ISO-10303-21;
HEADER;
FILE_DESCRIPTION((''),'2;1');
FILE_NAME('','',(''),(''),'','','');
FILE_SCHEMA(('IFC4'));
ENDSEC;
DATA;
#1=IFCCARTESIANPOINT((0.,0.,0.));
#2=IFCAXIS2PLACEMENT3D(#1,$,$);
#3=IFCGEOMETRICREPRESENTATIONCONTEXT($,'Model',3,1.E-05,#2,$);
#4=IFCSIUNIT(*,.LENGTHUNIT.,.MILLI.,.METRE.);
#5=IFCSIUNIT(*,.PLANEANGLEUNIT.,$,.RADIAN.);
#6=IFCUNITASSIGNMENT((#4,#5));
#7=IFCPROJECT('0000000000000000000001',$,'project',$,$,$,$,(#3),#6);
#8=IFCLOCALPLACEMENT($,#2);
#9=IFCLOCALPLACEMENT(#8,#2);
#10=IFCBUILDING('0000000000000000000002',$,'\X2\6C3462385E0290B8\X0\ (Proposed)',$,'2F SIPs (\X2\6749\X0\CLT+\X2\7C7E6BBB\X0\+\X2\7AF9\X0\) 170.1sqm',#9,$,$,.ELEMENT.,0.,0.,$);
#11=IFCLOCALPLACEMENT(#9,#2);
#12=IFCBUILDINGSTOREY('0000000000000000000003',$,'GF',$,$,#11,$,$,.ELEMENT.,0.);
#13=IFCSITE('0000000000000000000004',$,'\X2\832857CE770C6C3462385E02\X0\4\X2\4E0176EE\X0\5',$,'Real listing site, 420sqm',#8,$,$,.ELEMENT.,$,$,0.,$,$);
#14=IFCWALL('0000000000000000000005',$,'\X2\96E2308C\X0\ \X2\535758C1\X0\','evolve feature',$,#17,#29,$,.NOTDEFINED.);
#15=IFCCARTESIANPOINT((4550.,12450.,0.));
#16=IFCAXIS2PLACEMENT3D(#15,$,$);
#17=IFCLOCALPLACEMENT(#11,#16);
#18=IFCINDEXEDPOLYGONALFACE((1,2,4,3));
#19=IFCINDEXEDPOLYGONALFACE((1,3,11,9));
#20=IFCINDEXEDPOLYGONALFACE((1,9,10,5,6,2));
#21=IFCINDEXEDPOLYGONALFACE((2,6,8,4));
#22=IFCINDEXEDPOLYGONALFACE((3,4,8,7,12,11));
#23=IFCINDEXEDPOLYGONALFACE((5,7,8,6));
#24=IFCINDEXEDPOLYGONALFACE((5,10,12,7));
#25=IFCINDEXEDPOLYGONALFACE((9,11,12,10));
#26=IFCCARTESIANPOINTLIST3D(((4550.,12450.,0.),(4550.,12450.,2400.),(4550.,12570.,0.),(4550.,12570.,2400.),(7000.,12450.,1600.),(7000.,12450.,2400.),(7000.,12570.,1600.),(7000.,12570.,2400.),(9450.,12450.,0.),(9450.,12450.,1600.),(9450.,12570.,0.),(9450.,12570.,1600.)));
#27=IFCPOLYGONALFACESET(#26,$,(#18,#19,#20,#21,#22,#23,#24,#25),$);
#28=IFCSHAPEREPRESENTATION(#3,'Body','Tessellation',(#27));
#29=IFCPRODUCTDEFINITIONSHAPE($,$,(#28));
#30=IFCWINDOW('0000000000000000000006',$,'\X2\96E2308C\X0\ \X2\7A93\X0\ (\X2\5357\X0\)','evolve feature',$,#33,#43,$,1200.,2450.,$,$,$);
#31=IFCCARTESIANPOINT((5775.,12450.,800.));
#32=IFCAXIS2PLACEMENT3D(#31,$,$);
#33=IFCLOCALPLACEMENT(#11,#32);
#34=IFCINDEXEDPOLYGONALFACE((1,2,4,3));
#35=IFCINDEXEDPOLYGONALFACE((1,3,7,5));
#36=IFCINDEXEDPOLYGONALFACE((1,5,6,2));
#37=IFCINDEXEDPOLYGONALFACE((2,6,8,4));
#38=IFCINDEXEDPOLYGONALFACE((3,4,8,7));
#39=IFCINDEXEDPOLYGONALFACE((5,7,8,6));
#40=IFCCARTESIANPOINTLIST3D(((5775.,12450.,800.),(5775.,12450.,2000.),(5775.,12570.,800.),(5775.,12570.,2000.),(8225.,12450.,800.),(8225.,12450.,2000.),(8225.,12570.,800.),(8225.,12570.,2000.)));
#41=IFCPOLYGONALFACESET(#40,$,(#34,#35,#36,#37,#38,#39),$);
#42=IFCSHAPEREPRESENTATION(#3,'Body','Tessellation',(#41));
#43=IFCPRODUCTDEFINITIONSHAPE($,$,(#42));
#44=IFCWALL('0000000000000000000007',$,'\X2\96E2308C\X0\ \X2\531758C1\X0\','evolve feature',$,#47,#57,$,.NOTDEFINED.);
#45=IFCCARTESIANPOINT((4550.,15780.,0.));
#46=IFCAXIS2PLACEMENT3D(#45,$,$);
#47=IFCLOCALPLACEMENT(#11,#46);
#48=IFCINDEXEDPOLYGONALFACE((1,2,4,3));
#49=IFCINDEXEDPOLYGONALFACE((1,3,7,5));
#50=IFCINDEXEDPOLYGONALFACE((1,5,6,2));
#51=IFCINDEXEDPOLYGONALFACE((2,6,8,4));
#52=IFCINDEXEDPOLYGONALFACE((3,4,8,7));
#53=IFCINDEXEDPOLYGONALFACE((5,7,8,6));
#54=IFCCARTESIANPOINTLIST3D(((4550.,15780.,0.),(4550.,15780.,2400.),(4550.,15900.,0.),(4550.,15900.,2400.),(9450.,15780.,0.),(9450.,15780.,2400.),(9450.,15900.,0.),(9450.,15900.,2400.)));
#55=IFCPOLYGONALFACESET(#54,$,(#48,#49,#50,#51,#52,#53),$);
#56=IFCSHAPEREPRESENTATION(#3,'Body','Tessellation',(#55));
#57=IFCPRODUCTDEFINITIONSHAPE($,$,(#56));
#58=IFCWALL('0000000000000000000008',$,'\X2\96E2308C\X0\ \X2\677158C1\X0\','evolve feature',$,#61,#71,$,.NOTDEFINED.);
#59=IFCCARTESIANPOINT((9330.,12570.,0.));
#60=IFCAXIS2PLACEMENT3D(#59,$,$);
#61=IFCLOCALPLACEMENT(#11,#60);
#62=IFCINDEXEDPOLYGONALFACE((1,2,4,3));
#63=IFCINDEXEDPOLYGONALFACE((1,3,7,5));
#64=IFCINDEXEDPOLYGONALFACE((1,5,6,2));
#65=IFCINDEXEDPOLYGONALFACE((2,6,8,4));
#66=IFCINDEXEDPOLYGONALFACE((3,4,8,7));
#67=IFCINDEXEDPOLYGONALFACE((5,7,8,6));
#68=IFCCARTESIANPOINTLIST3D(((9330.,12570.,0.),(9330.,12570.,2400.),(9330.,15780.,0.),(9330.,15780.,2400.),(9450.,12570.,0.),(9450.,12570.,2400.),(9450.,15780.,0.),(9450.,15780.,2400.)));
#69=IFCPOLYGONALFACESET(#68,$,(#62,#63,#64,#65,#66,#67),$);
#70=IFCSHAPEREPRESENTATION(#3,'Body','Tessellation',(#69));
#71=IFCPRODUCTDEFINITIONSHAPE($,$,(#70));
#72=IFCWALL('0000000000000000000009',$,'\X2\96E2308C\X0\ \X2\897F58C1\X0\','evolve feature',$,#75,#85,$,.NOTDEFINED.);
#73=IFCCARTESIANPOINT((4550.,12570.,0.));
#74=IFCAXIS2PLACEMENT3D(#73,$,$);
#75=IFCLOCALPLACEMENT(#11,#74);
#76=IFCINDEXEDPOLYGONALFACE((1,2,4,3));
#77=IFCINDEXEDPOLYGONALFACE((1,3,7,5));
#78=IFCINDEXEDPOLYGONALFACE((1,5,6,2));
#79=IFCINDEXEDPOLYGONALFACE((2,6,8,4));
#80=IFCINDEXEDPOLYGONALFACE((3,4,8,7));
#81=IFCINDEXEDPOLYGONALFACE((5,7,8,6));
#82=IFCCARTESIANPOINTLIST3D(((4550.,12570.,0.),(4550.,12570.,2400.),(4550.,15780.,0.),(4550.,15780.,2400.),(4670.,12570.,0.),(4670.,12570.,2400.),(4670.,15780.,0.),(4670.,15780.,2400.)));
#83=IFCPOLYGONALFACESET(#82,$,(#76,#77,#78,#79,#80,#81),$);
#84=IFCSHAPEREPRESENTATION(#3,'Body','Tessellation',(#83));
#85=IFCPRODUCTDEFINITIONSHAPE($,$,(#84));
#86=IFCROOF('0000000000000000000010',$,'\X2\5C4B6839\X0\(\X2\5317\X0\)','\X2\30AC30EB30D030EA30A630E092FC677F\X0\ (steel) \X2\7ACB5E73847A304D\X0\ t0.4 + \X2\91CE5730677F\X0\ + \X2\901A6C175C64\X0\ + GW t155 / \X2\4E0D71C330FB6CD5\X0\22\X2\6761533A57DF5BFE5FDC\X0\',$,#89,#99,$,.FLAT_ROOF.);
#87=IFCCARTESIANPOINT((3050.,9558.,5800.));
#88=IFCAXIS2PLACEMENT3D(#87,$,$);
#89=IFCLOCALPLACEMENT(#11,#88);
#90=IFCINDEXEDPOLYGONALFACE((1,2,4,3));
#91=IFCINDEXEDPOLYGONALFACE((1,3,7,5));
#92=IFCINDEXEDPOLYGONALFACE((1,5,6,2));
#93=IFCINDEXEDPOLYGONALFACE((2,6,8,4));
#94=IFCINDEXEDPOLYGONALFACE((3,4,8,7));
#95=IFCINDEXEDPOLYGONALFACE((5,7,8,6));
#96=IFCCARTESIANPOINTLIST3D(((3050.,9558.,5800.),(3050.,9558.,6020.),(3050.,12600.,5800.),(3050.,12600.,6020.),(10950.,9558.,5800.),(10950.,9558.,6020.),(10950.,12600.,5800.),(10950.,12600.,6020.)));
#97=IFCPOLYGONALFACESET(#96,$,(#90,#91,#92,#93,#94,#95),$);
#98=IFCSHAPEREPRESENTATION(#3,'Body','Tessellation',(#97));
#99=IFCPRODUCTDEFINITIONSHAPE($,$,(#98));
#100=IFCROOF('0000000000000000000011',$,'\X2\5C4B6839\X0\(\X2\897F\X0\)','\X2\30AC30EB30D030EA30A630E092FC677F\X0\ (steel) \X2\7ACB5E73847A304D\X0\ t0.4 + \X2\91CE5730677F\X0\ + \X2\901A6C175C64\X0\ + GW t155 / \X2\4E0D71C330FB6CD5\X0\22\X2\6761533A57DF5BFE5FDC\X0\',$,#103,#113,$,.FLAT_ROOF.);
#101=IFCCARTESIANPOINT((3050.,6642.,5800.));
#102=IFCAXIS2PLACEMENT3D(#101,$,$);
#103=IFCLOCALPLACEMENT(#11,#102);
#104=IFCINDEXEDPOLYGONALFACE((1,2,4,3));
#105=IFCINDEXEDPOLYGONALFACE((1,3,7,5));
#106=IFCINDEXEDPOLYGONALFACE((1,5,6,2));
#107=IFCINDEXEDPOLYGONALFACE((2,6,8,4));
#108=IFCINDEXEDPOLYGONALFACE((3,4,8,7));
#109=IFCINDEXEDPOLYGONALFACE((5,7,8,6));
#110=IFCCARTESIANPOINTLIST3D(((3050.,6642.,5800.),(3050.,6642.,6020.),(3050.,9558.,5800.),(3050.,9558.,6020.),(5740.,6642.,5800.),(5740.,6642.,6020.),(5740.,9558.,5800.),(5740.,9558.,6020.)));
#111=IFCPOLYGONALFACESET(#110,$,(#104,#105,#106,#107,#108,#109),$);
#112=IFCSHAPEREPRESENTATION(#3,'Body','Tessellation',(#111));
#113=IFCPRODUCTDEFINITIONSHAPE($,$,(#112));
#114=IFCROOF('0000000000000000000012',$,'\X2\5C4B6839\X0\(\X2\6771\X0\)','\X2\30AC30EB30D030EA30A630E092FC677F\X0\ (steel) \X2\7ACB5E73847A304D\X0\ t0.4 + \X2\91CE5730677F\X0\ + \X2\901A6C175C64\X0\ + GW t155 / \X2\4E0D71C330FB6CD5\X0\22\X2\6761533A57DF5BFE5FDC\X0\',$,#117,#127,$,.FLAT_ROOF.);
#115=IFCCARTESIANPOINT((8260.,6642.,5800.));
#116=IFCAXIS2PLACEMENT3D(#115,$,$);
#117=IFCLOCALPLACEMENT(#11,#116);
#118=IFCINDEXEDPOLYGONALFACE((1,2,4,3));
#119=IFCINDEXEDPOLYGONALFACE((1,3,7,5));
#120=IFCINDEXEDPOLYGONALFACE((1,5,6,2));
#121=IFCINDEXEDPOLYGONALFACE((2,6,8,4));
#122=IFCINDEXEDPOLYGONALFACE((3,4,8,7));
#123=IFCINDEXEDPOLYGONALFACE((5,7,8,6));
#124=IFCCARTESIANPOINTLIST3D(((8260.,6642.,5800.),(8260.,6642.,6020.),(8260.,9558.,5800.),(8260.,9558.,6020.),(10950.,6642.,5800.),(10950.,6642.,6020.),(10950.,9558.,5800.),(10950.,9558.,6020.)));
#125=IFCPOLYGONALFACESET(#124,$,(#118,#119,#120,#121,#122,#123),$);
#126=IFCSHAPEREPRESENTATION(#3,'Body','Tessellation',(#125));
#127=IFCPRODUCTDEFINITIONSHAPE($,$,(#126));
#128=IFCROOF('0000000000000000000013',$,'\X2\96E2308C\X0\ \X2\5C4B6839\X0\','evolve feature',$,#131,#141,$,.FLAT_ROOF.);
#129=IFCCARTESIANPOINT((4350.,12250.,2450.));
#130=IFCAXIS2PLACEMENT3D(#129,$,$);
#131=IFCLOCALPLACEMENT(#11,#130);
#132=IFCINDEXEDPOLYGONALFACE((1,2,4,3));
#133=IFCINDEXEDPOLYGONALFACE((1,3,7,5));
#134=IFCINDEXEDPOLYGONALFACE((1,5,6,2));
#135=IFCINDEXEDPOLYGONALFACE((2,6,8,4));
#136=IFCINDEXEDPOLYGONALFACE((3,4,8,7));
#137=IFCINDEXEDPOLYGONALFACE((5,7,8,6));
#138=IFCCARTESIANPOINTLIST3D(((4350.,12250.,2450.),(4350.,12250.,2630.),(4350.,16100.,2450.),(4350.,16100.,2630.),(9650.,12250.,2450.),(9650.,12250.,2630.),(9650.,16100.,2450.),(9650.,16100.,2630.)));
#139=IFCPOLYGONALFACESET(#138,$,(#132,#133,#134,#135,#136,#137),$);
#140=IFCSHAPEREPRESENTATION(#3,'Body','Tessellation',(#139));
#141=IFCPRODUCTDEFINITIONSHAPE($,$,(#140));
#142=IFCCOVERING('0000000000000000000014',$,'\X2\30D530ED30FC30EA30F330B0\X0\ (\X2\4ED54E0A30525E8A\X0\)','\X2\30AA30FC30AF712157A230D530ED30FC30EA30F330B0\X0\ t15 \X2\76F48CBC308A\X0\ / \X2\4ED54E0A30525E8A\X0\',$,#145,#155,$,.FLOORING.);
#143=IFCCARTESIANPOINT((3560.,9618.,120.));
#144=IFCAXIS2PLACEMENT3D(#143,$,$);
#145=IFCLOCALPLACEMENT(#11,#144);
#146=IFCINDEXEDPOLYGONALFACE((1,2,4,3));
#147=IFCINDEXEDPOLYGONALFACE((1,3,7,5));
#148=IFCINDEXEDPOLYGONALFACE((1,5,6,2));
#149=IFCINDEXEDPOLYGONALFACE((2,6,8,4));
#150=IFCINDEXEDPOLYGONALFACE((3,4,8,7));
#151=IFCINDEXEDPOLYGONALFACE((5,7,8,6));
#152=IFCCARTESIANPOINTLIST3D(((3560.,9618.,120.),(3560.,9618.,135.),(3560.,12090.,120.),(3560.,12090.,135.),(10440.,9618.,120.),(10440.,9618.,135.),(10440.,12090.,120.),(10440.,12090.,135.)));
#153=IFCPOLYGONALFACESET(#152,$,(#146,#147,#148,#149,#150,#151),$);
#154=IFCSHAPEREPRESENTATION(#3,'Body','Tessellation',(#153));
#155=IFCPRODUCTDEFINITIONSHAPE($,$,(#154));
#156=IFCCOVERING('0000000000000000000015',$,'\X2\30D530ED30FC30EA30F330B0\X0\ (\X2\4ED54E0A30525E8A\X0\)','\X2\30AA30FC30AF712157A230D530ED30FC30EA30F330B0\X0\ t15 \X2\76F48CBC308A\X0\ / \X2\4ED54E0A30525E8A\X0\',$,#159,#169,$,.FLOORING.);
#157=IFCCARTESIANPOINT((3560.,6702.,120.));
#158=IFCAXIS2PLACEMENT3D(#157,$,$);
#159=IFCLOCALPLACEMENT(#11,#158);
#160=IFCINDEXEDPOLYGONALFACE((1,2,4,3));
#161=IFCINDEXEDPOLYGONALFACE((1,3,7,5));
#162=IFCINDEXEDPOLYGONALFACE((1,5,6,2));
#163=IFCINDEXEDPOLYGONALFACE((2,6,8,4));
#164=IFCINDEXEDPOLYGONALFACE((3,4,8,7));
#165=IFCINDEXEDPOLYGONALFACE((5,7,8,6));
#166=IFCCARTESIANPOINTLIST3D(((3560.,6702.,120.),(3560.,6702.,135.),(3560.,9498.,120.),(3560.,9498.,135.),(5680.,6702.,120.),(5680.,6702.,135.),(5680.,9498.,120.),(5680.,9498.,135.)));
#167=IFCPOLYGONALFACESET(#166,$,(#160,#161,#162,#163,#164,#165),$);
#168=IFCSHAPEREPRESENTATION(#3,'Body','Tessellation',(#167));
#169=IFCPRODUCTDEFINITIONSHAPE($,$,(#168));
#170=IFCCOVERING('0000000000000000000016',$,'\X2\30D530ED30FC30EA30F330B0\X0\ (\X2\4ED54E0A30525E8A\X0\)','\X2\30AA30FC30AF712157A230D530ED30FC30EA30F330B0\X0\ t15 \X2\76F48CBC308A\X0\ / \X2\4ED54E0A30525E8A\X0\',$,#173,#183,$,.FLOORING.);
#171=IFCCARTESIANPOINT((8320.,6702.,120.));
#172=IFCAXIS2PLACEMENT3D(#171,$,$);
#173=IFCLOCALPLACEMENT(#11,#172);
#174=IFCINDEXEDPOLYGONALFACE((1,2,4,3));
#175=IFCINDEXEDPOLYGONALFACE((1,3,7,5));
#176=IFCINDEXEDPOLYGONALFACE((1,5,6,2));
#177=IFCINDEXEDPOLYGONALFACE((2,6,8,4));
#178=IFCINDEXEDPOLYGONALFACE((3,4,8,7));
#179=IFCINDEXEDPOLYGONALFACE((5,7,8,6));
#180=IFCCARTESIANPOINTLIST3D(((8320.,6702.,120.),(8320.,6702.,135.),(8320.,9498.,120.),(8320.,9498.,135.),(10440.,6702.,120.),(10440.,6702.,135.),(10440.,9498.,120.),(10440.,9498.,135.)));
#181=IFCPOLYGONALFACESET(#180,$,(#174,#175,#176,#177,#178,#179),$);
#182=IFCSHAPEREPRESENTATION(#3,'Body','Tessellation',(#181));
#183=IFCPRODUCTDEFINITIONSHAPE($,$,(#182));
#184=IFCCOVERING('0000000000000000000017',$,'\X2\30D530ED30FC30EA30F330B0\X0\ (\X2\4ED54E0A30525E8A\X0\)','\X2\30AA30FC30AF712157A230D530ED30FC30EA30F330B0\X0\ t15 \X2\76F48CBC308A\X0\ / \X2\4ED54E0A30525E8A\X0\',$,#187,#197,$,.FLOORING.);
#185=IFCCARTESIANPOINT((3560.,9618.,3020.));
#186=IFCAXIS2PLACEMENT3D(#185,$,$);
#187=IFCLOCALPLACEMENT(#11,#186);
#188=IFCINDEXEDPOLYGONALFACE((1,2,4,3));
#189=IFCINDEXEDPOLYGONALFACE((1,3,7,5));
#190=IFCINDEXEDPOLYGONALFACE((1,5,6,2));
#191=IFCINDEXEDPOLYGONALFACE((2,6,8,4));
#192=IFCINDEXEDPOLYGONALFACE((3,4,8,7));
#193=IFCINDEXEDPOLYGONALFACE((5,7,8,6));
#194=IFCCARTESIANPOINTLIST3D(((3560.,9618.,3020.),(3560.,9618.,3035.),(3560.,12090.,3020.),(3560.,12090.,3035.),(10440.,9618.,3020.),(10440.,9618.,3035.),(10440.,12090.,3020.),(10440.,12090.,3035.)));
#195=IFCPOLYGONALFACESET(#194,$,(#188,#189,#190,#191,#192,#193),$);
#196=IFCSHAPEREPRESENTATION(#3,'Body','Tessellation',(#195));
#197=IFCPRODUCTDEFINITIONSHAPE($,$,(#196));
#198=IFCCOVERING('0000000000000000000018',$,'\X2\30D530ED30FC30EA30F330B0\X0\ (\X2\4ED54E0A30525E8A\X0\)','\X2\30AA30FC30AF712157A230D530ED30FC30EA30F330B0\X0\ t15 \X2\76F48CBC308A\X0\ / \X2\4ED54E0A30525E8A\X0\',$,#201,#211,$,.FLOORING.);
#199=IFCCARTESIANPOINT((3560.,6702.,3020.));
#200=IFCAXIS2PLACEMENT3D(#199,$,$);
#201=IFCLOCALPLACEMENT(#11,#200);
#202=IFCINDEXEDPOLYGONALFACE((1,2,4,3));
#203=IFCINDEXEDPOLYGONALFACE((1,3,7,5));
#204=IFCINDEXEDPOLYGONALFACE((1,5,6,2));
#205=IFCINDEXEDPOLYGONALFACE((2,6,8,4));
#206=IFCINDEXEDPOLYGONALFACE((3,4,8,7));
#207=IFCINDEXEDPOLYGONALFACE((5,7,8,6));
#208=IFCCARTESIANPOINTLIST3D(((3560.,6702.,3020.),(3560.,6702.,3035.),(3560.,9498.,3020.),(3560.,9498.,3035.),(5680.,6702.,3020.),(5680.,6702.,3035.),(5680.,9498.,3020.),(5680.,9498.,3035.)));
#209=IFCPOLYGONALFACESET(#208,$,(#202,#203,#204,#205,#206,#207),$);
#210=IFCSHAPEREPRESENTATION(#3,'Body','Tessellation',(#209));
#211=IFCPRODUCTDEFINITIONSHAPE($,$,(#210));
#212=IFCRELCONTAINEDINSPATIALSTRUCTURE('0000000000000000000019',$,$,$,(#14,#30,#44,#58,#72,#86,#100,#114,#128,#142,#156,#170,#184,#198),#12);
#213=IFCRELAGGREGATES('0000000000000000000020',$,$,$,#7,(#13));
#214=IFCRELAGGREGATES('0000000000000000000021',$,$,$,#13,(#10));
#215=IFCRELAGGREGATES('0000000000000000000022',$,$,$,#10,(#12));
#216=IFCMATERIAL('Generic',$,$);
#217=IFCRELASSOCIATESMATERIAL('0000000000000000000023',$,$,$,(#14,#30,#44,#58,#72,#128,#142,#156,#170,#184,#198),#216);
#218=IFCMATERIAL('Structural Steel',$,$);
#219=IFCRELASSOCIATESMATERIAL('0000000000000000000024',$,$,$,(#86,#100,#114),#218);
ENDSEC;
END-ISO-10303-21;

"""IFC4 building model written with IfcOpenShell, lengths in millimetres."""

from ifc_helpers import new_model, si_unit, frame, frame_2d, origin, place, context, project, spatial, rectangle, extrude, material, element, fill, save


model = new_model("IFC4")

# Units and contexts
model_context = context("Model", 3, precision=1e-05, world=origin())
ifc_project = project(units=[si_unit("LENGTHUNIT", "METRE", prefix="MILLI"), si_unit("PLANEANGLEUNIT", "RADIAN")], contexts=[model_context])

# Site, building, storey
site_placement = place(None, origin())
site = spatial("IfcSite", under=ifc_project, at=site_placement, Name="茨城県水戸市4丁目5", ObjectType="Real listing site, 420sqm", CompositionType="ELEMENT", RefElevation=0.0)
building_placement = place(site_placement, origin())
building = spatial("IfcBuilding", under=site, at=building_placement, Name="水戸市邸 (Proposed)", ObjectType="2F SIPs (杉CLT+籾殻+竹) 170.1sqm", CompositionType="ELEMENT", ElevationOfRefHeight=0.0, ElevationOfTerrain=0.0)
storey_placement = place(building_placement, origin())
storey = spatial("IfcBuildingStorey", under=building, at=storey_placement, Name="GF", CompositionType="ELEMENT", Elevation=0.0)

# Shared definitions
ifc_material_1 = material(Name="Generic")

# Wall, opening, window
wall_1_placement = place(storey_placement, frame((4550.0, 12450.0, 0.0)))
wall_1 = element("IfcWall", 1, at=wall_1_placement, inside=storey, material=ifc_material_1, Name="離れ 南壁", Description="evolve feature", PredefinedType="NOTDEFINED", context=model_context, shape_type="SweptSolid", body=[
    extrude(rectangle(XDim=4900.0, YDim=120.0, at=frame_2d((2450.0, 60.0))), frame((4550.0, 12450.0, 0.0)), (0.0, 0.0, 1.0), 2400.0),
])
opening_1_placement = place(storey_placement, frame((5775.0, 12450.0, 800.0)))
opening_1 = element("IfcOpeningElement", 2, at=opening_1_placement, cuts=wall_1, PredefinedType="NOTDEFINED", context=model_context, shape_type="SweptSolid", body=[
    extrude(rectangle(XDim=2450.0, YDim=120.0, at=frame_2d((1225.0, 60.0))), frame((5775.0, 12450.0, 800.0)), (0.0, 0.0, 1.0), 1200.0),
])
window_1_placement = place(storey_placement, frame((5775.0, 12450.0, 800.0)))
window_1 = element("IfcWindow", 3, at=window_1_placement, inside=storey, material=ifc_material_1, Name="離れ 窓 (南)", Description="evolve feature", OverallHeight=1200.0, OverallWidth=2450.0, context=model_context, shape_type="SweptSolid", body=[
    extrude(rectangle(XDim=2450.0, YDim=120.0, at=frame_2d((1225.0, 60.0))), frame((5775.0, 12450.0, 800.0)), (0.0, 0.0, 1.0), 1200.0),
])
fill(opening_1, window_1)

# Walls
wall_2_placement = place(storey_placement, frame((4550.0, 15780.0, 0.0)))
element("IfcWall", 4, at=wall_2_placement, inside=storey, material=ifc_material_1, Name="離れ 北壁", Description="evolve feature", PredefinedType="NOTDEFINED", context=model_context, shape_type="SweptSolid", body=[
    extrude(rectangle(XDim=4900.0, YDim=120.0, at=frame_2d((2450.0, 60.0))), frame((4550.0, 15780.0, 0.0)), (0.0, 0.0, 1.0), 2400.0),
])
wall_3_placement = place(storey_placement, frame((9330.0, 12570.0, 0.0)))
element("IfcWall", 5, at=wall_3_placement, inside=storey, material=ifc_material_1, Name="離れ 東壁", Description="evolve feature", PredefinedType="NOTDEFINED", context=model_context, shape_type="SweptSolid", body=[
    extrude(rectangle(XDim=120.0, YDim=3210.0, at=frame_2d((60.0, 1605.0))), frame((9330.0, 12570.0, 0.0)), (0.0, 0.0, 1.0), 2400.0),
])
wall_4_placement = place(storey_placement, frame((4550.0, 12570.0, 0.0)))
element("IfcWall", 6, at=wall_4_placement, inside=storey, material=ifc_material_1, Name="離れ 西壁", Description="evolve feature", PredefinedType="NOTDEFINED", context=model_context, shape_type="SweptSolid", body=[
    extrude(rectangle(XDim=120.0, YDim=3210.0, at=frame_2d((60.0, 1605.0))), frame((4550.0, 12570.0, 0.0)), (0.0, 0.0, 1.0), 2400.0),
])

# Roofs
ifc_material_2 = material(Name="Structural Steel")
for number, where, name in (
    (7, (3050.0, 9558.0, 5800.0), "屋根(北)"),
):
    element("IfcRoof", number, at=place(storey_placement, frame(where)), inside=storey, material=ifc_material_2, Name=name, Description="ガルバリウム鋼板 (steel) 立平葺き t0.4 + 野地板 + 通気層 + GW t155 / 不燃・法22条区域対応", PredefinedType="FLAT_ROOF", context=model_context, shape_type="SweptSolid", body=[
        extrude(rectangle(XDim=7900.0, YDim=3042.0, at=frame_2d((3950.0, 1521.0))), frame((3050.0, 9558.0, 5800.0)), (0.0, 0.0, 1.0), 220.0),
    ])
roof_1_placement = place(storey_placement, frame((3050.0, 6642.0, 5800.0)))
element("IfcRoof", 8, at=roof_1_placement, inside=storey, material=ifc_material_2, Name="屋根(西)", Description="ガルバリウム鋼板 (steel) 立平葺き t0.4 + 野地板 + 通気層 + GW t155 / 不燃・法22条区域対応", PredefinedType="FLAT_ROOF", context=model_context, shape_type="SweptSolid", body=[
    extrude(rectangle(XDim=2690.0, YDim=2916.0, at=frame_2d((1345.0, 1458.0))), frame((3050.0, 6642.0, 5800.0)), (0.0, 0.0, 1.0), 220.0),
])
roof_2_placement = place(storey_placement, frame((8260.0, 6642.0, 5800.0)))
element("IfcRoof", 9, at=roof_2_placement, inside=storey, material=ifc_material_2, Name="屋根(東)", Description="ガルバリウム鋼板 (steel) 立平葺き t0.4 + 野地板 + 通気層 + GW t155 / 不燃・法22条区域対応", PredefinedType="FLAT_ROOF", context=model_context, shape_type="SweptSolid", body=[
    extrude(rectangle(XDim=2690.0, YDim=2916.0, at=frame_2d((1345.0, 1458.0))), frame((8260.0, 6642.0, 5800.0)), (0.0, 0.0, 1.0), 220.0),
])
roof_3_placement = place(storey_placement, frame((4350.0, 12250.0, 2450.0)))
element("IfcRoof", 10, at=roof_3_placement, inside=storey, material=ifc_material_1, Name="離れ 屋根", Description="evolve feature", PredefinedType="FLAT_ROOF", context=model_context, shape_type="SweptSolid", body=[
    extrude(rectangle(XDim=5300.0, YDim=3850.0, at=frame_2d((2650.0, 1925.0))), frame((4350.0, 12250.0, 2450.0)), (0.0, 0.0, 1.0), 180.0),
])

# Coverings
covering_1_placement = place(storey_placement, frame((3560.0, 9618.0, 120.0)))
element("IfcCovering", 11, at=covering_1_placement, inside=storey, material=ifc_material_1, Name="フローリング (仕上げ床)", Description="オーク無垢フローリング t15 直貼り / 仕上げ床", PredefinedType="FLOORING", context=model_context, shape_type="SweptSolid", body=[
    extrude(rectangle(XDim=6880.0, YDim=2472.0, at=frame_2d((3440.0, 1236.0))), frame((3560.0, 9618.0, 120.0)), (0.0, 0.0, 1.0), 15.0),
])
covering_2_placement = place(storey_placement, frame((3560.0, 6702.0, 120.0)))
element("IfcCovering", 12, at=covering_2_placement, inside=storey, material=ifc_material_1, Name="フローリング (仕上げ床)", Description="オーク無垢フローリング t15 直貼り / 仕上げ床", PredefinedType="FLOORING", context=model_context, shape_type="SweptSolid", body=[
    extrude(rectangle(XDim=2120.0, YDim=2796.0, at=frame_2d((1060.0, 1398.0))), frame((3560.0, 6702.0, 120.0)), (0.0, 0.0, 1.0), 15.0),
])
covering_3_placement = place(storey_placement, frame((8320.0, 6702.0, 120.0)))
element("IfcCovering", 13, at=covering_3_placement, inside=storey, material=ifc_material_1, Name="フローリング (仕上げ床)", Description="オーク無垢フローリング t15 直貼り / 仕上げ床", PredefinedType="FLOORING", context=model_context, shape_type="SweptSolid", body=[
    extrude(rectangle(XDim=2120.0, YDim=2796.0, at=frame_2d((1060.0, 1398.0))), frame((8320.0, 6702.0, 120.0)), (0.0, 0.0, 1.0), 15.0),
])
covering_4_placement = place(storey_placement, frame((3560.0, 9618.0, 3020.0)))
element("IfcCovering", 14, at=covering_4_placement, inside=storey, material=ifc_material_1, Name="フローリング (仕上げ床)", Description="オーク無垢フローリング t15 直貼り / 仕上げ床", PredefinedType="FLOORING", context=model_context, shape_type="SweptSolid", body=[
    extrude(rectangle(XDim=6880.0, YDim=2472.0, at=frame_2d((3440.0, 1236.0))), frame((3560.0, 9618.0, 3020.0)), (0.0, 0.0, 1.0), 15.0),
])
covering_5_placement = place(storey_placement, frame((3560.0, 6702.0, 3020.0)))
element("IfcCovering", 15, at=covering_5_placement, inside=storey, material=ifc_material_1, Name="フローリング (仕上げ床)", Description="オーク無垢フローリング t15 直貼り / 仕上げ床", PredefinedType="FLOORING", context=model_context, shape_type="SweptSolid", body=[
    extrude(rectangle(XDim=2120.0, YDim=2796.0, at=frame_2d((1060.0, 1398.0))), frame((3560.0, 6702.0, 3020.0)), (0.0, 0.0, 1.0), 15.0),
])

save(model, "model.ifc")
